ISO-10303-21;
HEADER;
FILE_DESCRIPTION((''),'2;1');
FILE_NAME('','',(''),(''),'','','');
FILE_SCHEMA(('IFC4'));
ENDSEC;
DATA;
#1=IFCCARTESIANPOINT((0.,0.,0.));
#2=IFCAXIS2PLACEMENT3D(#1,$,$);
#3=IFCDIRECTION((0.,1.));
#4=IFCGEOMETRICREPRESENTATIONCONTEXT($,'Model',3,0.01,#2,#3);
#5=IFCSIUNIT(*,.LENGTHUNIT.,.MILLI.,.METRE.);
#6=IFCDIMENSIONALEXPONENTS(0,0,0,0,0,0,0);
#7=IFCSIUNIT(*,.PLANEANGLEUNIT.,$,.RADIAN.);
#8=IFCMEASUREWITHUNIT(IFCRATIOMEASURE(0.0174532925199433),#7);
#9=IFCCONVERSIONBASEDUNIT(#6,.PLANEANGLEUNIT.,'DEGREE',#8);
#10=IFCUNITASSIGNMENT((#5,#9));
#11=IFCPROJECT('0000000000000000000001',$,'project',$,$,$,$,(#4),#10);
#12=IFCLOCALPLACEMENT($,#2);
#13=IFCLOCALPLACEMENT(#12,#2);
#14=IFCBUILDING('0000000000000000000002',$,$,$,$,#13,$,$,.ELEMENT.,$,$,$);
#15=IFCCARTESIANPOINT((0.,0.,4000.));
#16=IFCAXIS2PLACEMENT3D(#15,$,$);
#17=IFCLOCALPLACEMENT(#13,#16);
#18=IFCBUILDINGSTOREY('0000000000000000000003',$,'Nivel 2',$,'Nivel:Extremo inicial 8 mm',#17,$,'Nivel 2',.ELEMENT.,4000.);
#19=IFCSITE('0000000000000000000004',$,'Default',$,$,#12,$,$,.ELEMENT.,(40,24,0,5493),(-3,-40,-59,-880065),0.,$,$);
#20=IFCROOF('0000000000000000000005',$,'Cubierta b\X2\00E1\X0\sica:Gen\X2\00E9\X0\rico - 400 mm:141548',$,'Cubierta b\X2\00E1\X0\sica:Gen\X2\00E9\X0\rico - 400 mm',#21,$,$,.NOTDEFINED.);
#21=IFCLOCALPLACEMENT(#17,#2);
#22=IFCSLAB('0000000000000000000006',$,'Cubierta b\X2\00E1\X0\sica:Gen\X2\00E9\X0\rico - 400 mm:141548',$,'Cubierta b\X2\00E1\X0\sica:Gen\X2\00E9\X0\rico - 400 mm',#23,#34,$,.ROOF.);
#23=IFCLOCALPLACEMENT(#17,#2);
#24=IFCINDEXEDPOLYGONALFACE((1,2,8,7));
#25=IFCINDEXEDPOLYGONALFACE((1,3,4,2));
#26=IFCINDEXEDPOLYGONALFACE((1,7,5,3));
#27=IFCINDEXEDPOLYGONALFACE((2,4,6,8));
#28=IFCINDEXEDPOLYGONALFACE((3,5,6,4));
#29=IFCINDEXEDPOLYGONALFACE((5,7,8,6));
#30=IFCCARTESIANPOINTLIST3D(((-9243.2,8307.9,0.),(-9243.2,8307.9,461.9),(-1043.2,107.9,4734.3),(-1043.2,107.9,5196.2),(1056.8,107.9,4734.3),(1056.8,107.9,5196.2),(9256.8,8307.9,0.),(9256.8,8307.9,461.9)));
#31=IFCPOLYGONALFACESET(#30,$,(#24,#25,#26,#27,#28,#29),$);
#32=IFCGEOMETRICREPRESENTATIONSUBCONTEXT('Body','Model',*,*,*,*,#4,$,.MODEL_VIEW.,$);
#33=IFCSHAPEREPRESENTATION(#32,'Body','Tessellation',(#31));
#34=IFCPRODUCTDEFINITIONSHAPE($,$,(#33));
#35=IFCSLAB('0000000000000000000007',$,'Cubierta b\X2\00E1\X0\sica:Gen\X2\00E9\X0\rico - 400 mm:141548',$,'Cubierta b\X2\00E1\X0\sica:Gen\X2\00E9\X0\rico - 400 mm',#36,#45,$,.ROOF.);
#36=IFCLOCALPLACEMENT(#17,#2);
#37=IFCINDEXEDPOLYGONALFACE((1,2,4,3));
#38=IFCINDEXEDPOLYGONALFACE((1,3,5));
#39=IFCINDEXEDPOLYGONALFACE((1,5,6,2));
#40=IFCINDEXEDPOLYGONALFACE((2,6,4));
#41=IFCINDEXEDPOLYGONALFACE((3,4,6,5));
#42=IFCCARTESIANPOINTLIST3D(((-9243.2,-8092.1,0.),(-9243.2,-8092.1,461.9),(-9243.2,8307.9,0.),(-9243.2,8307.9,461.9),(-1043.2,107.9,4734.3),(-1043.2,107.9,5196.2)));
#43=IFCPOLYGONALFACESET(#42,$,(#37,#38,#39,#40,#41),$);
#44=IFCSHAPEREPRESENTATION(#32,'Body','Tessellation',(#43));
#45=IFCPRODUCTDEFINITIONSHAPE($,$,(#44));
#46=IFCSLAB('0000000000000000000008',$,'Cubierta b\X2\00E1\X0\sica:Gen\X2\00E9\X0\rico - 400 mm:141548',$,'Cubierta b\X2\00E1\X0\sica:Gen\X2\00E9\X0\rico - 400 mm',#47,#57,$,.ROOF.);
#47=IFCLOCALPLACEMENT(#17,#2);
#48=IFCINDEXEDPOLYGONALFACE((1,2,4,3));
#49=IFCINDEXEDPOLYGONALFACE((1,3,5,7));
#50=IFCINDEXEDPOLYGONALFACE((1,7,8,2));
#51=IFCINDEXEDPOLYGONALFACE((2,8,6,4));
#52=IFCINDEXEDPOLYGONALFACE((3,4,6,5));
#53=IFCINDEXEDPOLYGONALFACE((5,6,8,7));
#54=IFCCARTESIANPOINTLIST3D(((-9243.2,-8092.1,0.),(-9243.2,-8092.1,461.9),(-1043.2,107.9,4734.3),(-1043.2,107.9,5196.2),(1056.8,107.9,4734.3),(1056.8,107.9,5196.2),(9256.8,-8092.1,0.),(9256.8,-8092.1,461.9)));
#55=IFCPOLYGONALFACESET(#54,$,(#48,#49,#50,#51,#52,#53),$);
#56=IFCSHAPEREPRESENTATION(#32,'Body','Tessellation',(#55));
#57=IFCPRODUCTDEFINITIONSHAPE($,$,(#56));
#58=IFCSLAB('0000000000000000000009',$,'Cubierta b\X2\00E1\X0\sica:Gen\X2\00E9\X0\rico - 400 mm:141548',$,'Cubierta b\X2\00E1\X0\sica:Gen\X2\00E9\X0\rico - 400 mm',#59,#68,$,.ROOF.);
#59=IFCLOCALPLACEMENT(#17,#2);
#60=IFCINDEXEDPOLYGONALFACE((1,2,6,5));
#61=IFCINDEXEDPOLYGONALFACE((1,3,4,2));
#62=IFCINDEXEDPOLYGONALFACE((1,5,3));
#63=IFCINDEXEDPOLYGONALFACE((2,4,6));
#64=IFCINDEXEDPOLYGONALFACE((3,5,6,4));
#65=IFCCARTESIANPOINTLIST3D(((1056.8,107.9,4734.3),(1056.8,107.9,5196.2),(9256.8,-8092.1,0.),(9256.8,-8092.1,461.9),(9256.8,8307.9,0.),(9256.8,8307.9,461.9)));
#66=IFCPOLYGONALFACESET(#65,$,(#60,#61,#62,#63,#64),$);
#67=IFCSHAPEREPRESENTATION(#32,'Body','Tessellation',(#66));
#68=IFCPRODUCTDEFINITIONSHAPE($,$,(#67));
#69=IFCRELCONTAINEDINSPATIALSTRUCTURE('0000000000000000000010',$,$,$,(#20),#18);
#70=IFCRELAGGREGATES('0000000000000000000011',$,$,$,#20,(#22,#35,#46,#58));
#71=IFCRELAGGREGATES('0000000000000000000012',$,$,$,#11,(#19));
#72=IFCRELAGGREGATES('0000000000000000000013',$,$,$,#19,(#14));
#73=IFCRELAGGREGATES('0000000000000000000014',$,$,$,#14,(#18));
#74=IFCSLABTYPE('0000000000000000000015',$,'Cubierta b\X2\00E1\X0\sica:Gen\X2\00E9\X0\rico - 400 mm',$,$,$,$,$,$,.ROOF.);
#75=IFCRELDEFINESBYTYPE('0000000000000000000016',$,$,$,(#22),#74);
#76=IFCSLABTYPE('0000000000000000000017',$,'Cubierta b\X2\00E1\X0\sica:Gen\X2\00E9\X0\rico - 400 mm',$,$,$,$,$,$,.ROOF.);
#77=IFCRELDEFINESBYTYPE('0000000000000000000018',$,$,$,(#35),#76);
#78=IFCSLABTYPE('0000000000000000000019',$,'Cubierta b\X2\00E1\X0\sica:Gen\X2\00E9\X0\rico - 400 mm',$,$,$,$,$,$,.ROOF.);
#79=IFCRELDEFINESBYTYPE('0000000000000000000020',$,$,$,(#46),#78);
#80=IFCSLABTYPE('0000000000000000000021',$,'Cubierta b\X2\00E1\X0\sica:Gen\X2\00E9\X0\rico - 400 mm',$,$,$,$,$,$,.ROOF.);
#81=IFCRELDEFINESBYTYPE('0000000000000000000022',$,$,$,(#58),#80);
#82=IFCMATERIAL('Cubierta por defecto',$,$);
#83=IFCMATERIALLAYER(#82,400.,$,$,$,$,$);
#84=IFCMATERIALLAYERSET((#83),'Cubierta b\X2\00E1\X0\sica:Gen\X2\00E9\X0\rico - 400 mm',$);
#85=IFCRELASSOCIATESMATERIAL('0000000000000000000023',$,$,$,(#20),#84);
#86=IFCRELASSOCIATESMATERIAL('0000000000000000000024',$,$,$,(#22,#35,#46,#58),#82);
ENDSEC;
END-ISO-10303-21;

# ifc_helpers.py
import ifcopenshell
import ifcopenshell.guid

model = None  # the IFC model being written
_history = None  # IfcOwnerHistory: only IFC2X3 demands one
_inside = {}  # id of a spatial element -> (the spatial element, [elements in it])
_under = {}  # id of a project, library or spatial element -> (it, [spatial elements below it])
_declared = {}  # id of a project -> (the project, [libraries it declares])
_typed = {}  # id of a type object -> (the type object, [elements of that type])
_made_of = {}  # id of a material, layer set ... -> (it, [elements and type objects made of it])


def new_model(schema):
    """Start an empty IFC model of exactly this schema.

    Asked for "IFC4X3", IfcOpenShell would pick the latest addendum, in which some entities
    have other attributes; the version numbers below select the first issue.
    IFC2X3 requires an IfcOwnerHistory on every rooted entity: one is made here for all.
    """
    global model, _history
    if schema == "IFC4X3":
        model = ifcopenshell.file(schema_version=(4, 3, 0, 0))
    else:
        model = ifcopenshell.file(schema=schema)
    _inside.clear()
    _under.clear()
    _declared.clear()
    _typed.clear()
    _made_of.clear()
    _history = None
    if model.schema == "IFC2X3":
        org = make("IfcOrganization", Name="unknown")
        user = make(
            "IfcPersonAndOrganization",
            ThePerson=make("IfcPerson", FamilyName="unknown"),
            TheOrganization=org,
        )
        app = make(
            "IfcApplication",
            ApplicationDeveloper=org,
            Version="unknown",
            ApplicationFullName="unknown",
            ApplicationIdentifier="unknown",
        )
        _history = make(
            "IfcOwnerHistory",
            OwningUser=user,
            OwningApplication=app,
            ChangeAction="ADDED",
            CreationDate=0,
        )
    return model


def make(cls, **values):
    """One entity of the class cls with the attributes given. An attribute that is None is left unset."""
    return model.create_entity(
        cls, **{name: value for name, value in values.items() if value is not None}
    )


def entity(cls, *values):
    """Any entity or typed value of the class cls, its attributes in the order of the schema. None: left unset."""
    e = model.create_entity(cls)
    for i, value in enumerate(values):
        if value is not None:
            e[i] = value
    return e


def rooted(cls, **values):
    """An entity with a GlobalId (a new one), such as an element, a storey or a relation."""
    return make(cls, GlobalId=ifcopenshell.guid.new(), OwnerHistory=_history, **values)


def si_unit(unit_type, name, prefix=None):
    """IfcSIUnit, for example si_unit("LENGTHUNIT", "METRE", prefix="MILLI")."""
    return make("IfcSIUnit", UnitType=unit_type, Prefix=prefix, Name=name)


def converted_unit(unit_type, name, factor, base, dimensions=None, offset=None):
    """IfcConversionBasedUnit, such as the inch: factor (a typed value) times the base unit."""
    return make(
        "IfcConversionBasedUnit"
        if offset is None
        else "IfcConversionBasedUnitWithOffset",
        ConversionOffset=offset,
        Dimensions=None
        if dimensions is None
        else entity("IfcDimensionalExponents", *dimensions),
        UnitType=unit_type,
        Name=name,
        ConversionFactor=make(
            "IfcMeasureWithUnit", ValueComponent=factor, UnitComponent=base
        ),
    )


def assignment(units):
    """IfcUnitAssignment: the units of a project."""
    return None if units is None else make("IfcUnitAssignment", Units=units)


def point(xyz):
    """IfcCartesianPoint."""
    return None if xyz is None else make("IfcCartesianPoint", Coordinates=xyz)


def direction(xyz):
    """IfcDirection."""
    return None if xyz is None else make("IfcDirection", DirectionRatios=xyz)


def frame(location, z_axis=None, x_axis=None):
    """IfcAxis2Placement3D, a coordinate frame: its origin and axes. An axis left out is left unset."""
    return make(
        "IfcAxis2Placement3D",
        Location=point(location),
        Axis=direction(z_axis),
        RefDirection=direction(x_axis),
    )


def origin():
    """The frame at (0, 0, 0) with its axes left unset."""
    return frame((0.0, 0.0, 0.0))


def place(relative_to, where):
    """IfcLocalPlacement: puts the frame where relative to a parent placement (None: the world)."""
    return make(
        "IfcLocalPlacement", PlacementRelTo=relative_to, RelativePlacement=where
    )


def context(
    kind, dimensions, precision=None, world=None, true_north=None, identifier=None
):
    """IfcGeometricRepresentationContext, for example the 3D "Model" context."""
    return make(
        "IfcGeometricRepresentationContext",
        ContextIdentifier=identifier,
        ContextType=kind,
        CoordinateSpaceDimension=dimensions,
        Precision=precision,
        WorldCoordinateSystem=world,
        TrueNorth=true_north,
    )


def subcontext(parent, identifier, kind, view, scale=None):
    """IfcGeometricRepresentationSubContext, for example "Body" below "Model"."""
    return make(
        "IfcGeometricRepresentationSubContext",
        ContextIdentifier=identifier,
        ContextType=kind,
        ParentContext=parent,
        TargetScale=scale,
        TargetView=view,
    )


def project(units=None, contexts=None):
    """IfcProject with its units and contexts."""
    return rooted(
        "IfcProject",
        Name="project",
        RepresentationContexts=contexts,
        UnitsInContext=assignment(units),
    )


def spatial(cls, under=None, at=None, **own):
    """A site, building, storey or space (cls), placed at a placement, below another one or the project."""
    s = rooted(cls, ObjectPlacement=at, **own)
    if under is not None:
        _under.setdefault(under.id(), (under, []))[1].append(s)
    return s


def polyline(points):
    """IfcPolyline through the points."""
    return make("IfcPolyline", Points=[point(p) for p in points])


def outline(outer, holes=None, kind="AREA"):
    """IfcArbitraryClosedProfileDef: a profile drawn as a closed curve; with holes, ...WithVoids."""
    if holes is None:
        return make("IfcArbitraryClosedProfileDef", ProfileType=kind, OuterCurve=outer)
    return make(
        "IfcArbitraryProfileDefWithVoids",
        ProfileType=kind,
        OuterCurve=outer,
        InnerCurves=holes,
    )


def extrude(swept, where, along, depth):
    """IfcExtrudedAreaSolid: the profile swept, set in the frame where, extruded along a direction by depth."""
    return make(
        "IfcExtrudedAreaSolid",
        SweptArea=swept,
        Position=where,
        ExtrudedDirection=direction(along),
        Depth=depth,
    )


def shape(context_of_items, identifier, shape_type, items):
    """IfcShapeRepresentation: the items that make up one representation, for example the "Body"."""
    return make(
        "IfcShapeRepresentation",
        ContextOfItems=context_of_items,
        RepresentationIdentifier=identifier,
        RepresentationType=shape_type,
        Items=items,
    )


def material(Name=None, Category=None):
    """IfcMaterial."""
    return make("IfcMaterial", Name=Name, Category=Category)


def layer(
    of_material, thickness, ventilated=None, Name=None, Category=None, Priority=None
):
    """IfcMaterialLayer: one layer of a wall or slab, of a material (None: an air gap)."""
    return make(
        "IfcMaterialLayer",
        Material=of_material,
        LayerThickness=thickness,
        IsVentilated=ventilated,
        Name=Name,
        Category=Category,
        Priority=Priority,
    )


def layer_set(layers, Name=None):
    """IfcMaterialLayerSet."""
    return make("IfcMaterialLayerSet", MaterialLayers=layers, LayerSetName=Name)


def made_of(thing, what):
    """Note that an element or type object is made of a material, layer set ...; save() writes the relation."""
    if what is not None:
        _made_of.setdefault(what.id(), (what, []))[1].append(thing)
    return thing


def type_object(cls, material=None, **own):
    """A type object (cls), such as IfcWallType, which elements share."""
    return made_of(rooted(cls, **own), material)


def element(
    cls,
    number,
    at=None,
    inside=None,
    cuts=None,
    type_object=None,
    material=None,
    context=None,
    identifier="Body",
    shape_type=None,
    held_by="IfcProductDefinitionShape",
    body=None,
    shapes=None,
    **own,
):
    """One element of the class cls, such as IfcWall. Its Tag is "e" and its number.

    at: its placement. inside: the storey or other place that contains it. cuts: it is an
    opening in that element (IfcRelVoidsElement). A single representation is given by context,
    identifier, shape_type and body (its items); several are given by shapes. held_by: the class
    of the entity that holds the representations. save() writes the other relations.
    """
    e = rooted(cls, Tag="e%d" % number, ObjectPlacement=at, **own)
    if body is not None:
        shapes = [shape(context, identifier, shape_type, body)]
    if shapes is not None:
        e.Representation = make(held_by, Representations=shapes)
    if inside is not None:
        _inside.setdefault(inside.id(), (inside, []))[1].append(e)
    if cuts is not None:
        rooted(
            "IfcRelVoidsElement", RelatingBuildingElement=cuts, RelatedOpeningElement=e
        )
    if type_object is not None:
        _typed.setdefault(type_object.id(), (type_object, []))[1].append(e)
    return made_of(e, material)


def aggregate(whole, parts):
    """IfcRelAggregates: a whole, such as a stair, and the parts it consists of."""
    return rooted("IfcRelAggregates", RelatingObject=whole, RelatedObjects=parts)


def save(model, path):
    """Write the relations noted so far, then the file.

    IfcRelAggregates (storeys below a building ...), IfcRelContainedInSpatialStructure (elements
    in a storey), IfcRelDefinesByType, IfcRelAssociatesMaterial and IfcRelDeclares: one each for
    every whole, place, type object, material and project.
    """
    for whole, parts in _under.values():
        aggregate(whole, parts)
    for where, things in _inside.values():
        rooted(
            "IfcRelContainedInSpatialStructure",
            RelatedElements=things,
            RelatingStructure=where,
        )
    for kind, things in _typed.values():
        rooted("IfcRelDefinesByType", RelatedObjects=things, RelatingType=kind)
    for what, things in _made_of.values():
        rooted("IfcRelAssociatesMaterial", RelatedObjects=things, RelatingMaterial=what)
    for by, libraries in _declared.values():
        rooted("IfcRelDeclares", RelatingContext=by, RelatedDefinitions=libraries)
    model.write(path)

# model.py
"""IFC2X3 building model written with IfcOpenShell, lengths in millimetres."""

from ifc_helpers import new_model, entity, si_unit, converted_unit, direction, frame, origin, place, context, subcontext, project, spatial, polyline, outline, extrude, material, layer, layer_set, type_object, element, aggregate, save


model = new_model("IFC2X3")

# Units and contexts
model_context = context("Model", 3, precision=0.01, world=origin(), true_north=direction((0.0, 1.0)))
body_context = subcontext(model_context, "Body", "Model", "MODEL_VIEW")
ifc_project = project(units=[si_unit("LENGTHUNIT", "METRE", prefix="MILLI"), converted_unit("PLANEANGLEUNIT", "DEGREE", entity("IfcRatioMeasure", 0.0174532925199433), si_unit("PLANEANGLEUNIT", "RADIAN"), dimensions=[0, 0, 0, 0, 0, 0, 0])], contexts=[model_context])

# Site, building, storey
site_placement = place(None, origin())
site = spatial("IfcSite", under=ifc_project, at=site_placement, Name="Default", CompositionType="ELEMENT", RefLatitude=(40, 24, 0, 5493), RefLongitude=(-3, -40, -59, -880065), RefElevation=0.0)
building_placement = place(site_placement, origin())
building = spatial("IfcBuilding", under=site, at=building_placement, CompositionType="ELEMENT")
storey_placement = place(building_placement, frame((0.0, 0.0, 4000.0)))
storey = spatial("IfcBuildingStorey", under=building, at=storey_placement, Name="Nivel 2", ObjectType="Nivel:Extremo inicial 8 mm", LongName="Nivel 2", CompositionType="ELEMENT", Elevation=4000.0)

# Roof, slabs
ifc_material = material(Name="Cubierta por defecto")
ifc_layer = layer(ifc_material, 400.0)
ifc_layer_set = layer_set([ifc_layer], Name="Cubierta básica:Genérico - 400 mm")
roof_placement = place(storey_placement, frame((-9243.2, -8092.1, 0.0)))
roof = element("IfcRoof", 1, at=roof_placement, inside=storey, material=ifc_layer_set, Name="Cubierta básica:Genérico - 400 mm:141548", ObjectType="Cubierta básica:Genérico - 400 mm", ShapeType="NOTDEFINED")
slab_type_1 = type_object("IfcSlabType", Name="Cubierta básica:Genérico - 400 mm", PredefinedType="ROOF")
slab_1_placement = place(roof_placement, origin())
slab_1 = element("IfcSlab", 2, at=slab_1_placement, type_object=slab_type_1, material=ifc_material, Name="Cubierta básica:Genérico - 400 mm:141548", ObjectType="Cubierta básica:Genérico - 400 mm", PredefinedType="ROOF", context=body_context, shape_type="SweptSolid", body=[
    extrude(outline(polyline([(9250.0, 4734.3), (-9250.0, 4734.3), (-1050.0, -4734.3), (1050.0, -4734.3), (9250.0, 4734.3)])), frame((9250.0, 12300.0, 2367.1), z_axis=(0.0, 0.5, 0.866025), x_axis=(1.0, 0.0, 0.0)), (0.0, -0.5, 0.866025), 461.9),
])
slab_type_2 = type_object("IfcSlabType", Name="Cubierta básica:Genérico - 400 mm", PredefinedType="ROOF")
slab_2_placement = place(roof_placement, origin())
slab_2 = element("IfcSlab", 3, at=slab_2_placement, type_object=slab_type_2, material=ifc_material, Name="Cubierta básica:Genérico - 400 mm:141548", ObjectType="Cubierta básica:Genérico - 400 mm", PredefinedType="ROOF", context=body_context, shape_type="SweptSolid", body=[
    extrude(outline(polyline([(-4734.3, 8200.0), (-4734.3, -8200.0), (4734.3, 0.0), (-4734.3, 8200.0)])), frame((4100.0, 8200.0, 2367.1), z_axis=(-0.5, 0.0, 0.866025), x_axis=(0.866025, 0.0, 0.5)), (0.5, 0.0, 0.866025), 461.9),
])
slab_type_3 = type_object("IfcSlabType", Name="Cubierta básica:Genérico - 400 mm", PredefinedType="ROOF")
slab_3_placement = place(roof_placement, origin())
slab_3 = element("IfcSlab", 4, at=slab_3_placement, type_object=slab_type_3, material=ifc_material, Name="Cubierta básica:Genérico - 400 mm:141548", ObjectType="Cubierta básica:Genérico - 400 mm", PredefinedType="ROOF", context=body_context, shape_type="SweptSolid", body=[
    extrude(outline(polyline([(-9250.0, -4734.3), (9250.0, -4734.3), (1050.0, 4734.3), (-1050.0, 4734.3), (-9250.0, -4734.3)])), frame((9250.0, 4100.0, 2367.1), z_axis=(0.0, -0.5, 0.866025), x_axis=(1.0, 0.0, 0.0)), (0.0, 0.5, 0.866025), 461.9),
])
slab_type_4 = type_object("IfcSlabType", Name="Cubierta básica:Genérico - 400 mm", PredefinedType="ROOF")
slab_4_placement = place(roof_placement, origin())
slab_4 = element("IfcSlab", 5, at=slab_4_placement, type_object=slab_type_4, material=ifc_material, Name="Cubierta básica:Genérico - 400 mm:141548", ObjectType="Cubierta básica:Genérico - 400 mm", PredefinedType="ROOF", context=body_context, shape_type="SweptSolid", body=[
    extrude(outline(polyline([(-4734.3, 0.0), (4734.3, -8200.0), (4734.3, 8200.0), (-4734.3, 0.0)])), frame((14400.0, 8200.0, 2367.1), z_axis=(0.5, 0.0, 0.866025), x_axis=(0.866025, 0.0, -0.5)), (-0.5, 0.0, 0.866025), 461.9),
])
aggregate(roof, [slab_1, slab_2, slab_3, slab_4])

save(model, "model.ifc")
